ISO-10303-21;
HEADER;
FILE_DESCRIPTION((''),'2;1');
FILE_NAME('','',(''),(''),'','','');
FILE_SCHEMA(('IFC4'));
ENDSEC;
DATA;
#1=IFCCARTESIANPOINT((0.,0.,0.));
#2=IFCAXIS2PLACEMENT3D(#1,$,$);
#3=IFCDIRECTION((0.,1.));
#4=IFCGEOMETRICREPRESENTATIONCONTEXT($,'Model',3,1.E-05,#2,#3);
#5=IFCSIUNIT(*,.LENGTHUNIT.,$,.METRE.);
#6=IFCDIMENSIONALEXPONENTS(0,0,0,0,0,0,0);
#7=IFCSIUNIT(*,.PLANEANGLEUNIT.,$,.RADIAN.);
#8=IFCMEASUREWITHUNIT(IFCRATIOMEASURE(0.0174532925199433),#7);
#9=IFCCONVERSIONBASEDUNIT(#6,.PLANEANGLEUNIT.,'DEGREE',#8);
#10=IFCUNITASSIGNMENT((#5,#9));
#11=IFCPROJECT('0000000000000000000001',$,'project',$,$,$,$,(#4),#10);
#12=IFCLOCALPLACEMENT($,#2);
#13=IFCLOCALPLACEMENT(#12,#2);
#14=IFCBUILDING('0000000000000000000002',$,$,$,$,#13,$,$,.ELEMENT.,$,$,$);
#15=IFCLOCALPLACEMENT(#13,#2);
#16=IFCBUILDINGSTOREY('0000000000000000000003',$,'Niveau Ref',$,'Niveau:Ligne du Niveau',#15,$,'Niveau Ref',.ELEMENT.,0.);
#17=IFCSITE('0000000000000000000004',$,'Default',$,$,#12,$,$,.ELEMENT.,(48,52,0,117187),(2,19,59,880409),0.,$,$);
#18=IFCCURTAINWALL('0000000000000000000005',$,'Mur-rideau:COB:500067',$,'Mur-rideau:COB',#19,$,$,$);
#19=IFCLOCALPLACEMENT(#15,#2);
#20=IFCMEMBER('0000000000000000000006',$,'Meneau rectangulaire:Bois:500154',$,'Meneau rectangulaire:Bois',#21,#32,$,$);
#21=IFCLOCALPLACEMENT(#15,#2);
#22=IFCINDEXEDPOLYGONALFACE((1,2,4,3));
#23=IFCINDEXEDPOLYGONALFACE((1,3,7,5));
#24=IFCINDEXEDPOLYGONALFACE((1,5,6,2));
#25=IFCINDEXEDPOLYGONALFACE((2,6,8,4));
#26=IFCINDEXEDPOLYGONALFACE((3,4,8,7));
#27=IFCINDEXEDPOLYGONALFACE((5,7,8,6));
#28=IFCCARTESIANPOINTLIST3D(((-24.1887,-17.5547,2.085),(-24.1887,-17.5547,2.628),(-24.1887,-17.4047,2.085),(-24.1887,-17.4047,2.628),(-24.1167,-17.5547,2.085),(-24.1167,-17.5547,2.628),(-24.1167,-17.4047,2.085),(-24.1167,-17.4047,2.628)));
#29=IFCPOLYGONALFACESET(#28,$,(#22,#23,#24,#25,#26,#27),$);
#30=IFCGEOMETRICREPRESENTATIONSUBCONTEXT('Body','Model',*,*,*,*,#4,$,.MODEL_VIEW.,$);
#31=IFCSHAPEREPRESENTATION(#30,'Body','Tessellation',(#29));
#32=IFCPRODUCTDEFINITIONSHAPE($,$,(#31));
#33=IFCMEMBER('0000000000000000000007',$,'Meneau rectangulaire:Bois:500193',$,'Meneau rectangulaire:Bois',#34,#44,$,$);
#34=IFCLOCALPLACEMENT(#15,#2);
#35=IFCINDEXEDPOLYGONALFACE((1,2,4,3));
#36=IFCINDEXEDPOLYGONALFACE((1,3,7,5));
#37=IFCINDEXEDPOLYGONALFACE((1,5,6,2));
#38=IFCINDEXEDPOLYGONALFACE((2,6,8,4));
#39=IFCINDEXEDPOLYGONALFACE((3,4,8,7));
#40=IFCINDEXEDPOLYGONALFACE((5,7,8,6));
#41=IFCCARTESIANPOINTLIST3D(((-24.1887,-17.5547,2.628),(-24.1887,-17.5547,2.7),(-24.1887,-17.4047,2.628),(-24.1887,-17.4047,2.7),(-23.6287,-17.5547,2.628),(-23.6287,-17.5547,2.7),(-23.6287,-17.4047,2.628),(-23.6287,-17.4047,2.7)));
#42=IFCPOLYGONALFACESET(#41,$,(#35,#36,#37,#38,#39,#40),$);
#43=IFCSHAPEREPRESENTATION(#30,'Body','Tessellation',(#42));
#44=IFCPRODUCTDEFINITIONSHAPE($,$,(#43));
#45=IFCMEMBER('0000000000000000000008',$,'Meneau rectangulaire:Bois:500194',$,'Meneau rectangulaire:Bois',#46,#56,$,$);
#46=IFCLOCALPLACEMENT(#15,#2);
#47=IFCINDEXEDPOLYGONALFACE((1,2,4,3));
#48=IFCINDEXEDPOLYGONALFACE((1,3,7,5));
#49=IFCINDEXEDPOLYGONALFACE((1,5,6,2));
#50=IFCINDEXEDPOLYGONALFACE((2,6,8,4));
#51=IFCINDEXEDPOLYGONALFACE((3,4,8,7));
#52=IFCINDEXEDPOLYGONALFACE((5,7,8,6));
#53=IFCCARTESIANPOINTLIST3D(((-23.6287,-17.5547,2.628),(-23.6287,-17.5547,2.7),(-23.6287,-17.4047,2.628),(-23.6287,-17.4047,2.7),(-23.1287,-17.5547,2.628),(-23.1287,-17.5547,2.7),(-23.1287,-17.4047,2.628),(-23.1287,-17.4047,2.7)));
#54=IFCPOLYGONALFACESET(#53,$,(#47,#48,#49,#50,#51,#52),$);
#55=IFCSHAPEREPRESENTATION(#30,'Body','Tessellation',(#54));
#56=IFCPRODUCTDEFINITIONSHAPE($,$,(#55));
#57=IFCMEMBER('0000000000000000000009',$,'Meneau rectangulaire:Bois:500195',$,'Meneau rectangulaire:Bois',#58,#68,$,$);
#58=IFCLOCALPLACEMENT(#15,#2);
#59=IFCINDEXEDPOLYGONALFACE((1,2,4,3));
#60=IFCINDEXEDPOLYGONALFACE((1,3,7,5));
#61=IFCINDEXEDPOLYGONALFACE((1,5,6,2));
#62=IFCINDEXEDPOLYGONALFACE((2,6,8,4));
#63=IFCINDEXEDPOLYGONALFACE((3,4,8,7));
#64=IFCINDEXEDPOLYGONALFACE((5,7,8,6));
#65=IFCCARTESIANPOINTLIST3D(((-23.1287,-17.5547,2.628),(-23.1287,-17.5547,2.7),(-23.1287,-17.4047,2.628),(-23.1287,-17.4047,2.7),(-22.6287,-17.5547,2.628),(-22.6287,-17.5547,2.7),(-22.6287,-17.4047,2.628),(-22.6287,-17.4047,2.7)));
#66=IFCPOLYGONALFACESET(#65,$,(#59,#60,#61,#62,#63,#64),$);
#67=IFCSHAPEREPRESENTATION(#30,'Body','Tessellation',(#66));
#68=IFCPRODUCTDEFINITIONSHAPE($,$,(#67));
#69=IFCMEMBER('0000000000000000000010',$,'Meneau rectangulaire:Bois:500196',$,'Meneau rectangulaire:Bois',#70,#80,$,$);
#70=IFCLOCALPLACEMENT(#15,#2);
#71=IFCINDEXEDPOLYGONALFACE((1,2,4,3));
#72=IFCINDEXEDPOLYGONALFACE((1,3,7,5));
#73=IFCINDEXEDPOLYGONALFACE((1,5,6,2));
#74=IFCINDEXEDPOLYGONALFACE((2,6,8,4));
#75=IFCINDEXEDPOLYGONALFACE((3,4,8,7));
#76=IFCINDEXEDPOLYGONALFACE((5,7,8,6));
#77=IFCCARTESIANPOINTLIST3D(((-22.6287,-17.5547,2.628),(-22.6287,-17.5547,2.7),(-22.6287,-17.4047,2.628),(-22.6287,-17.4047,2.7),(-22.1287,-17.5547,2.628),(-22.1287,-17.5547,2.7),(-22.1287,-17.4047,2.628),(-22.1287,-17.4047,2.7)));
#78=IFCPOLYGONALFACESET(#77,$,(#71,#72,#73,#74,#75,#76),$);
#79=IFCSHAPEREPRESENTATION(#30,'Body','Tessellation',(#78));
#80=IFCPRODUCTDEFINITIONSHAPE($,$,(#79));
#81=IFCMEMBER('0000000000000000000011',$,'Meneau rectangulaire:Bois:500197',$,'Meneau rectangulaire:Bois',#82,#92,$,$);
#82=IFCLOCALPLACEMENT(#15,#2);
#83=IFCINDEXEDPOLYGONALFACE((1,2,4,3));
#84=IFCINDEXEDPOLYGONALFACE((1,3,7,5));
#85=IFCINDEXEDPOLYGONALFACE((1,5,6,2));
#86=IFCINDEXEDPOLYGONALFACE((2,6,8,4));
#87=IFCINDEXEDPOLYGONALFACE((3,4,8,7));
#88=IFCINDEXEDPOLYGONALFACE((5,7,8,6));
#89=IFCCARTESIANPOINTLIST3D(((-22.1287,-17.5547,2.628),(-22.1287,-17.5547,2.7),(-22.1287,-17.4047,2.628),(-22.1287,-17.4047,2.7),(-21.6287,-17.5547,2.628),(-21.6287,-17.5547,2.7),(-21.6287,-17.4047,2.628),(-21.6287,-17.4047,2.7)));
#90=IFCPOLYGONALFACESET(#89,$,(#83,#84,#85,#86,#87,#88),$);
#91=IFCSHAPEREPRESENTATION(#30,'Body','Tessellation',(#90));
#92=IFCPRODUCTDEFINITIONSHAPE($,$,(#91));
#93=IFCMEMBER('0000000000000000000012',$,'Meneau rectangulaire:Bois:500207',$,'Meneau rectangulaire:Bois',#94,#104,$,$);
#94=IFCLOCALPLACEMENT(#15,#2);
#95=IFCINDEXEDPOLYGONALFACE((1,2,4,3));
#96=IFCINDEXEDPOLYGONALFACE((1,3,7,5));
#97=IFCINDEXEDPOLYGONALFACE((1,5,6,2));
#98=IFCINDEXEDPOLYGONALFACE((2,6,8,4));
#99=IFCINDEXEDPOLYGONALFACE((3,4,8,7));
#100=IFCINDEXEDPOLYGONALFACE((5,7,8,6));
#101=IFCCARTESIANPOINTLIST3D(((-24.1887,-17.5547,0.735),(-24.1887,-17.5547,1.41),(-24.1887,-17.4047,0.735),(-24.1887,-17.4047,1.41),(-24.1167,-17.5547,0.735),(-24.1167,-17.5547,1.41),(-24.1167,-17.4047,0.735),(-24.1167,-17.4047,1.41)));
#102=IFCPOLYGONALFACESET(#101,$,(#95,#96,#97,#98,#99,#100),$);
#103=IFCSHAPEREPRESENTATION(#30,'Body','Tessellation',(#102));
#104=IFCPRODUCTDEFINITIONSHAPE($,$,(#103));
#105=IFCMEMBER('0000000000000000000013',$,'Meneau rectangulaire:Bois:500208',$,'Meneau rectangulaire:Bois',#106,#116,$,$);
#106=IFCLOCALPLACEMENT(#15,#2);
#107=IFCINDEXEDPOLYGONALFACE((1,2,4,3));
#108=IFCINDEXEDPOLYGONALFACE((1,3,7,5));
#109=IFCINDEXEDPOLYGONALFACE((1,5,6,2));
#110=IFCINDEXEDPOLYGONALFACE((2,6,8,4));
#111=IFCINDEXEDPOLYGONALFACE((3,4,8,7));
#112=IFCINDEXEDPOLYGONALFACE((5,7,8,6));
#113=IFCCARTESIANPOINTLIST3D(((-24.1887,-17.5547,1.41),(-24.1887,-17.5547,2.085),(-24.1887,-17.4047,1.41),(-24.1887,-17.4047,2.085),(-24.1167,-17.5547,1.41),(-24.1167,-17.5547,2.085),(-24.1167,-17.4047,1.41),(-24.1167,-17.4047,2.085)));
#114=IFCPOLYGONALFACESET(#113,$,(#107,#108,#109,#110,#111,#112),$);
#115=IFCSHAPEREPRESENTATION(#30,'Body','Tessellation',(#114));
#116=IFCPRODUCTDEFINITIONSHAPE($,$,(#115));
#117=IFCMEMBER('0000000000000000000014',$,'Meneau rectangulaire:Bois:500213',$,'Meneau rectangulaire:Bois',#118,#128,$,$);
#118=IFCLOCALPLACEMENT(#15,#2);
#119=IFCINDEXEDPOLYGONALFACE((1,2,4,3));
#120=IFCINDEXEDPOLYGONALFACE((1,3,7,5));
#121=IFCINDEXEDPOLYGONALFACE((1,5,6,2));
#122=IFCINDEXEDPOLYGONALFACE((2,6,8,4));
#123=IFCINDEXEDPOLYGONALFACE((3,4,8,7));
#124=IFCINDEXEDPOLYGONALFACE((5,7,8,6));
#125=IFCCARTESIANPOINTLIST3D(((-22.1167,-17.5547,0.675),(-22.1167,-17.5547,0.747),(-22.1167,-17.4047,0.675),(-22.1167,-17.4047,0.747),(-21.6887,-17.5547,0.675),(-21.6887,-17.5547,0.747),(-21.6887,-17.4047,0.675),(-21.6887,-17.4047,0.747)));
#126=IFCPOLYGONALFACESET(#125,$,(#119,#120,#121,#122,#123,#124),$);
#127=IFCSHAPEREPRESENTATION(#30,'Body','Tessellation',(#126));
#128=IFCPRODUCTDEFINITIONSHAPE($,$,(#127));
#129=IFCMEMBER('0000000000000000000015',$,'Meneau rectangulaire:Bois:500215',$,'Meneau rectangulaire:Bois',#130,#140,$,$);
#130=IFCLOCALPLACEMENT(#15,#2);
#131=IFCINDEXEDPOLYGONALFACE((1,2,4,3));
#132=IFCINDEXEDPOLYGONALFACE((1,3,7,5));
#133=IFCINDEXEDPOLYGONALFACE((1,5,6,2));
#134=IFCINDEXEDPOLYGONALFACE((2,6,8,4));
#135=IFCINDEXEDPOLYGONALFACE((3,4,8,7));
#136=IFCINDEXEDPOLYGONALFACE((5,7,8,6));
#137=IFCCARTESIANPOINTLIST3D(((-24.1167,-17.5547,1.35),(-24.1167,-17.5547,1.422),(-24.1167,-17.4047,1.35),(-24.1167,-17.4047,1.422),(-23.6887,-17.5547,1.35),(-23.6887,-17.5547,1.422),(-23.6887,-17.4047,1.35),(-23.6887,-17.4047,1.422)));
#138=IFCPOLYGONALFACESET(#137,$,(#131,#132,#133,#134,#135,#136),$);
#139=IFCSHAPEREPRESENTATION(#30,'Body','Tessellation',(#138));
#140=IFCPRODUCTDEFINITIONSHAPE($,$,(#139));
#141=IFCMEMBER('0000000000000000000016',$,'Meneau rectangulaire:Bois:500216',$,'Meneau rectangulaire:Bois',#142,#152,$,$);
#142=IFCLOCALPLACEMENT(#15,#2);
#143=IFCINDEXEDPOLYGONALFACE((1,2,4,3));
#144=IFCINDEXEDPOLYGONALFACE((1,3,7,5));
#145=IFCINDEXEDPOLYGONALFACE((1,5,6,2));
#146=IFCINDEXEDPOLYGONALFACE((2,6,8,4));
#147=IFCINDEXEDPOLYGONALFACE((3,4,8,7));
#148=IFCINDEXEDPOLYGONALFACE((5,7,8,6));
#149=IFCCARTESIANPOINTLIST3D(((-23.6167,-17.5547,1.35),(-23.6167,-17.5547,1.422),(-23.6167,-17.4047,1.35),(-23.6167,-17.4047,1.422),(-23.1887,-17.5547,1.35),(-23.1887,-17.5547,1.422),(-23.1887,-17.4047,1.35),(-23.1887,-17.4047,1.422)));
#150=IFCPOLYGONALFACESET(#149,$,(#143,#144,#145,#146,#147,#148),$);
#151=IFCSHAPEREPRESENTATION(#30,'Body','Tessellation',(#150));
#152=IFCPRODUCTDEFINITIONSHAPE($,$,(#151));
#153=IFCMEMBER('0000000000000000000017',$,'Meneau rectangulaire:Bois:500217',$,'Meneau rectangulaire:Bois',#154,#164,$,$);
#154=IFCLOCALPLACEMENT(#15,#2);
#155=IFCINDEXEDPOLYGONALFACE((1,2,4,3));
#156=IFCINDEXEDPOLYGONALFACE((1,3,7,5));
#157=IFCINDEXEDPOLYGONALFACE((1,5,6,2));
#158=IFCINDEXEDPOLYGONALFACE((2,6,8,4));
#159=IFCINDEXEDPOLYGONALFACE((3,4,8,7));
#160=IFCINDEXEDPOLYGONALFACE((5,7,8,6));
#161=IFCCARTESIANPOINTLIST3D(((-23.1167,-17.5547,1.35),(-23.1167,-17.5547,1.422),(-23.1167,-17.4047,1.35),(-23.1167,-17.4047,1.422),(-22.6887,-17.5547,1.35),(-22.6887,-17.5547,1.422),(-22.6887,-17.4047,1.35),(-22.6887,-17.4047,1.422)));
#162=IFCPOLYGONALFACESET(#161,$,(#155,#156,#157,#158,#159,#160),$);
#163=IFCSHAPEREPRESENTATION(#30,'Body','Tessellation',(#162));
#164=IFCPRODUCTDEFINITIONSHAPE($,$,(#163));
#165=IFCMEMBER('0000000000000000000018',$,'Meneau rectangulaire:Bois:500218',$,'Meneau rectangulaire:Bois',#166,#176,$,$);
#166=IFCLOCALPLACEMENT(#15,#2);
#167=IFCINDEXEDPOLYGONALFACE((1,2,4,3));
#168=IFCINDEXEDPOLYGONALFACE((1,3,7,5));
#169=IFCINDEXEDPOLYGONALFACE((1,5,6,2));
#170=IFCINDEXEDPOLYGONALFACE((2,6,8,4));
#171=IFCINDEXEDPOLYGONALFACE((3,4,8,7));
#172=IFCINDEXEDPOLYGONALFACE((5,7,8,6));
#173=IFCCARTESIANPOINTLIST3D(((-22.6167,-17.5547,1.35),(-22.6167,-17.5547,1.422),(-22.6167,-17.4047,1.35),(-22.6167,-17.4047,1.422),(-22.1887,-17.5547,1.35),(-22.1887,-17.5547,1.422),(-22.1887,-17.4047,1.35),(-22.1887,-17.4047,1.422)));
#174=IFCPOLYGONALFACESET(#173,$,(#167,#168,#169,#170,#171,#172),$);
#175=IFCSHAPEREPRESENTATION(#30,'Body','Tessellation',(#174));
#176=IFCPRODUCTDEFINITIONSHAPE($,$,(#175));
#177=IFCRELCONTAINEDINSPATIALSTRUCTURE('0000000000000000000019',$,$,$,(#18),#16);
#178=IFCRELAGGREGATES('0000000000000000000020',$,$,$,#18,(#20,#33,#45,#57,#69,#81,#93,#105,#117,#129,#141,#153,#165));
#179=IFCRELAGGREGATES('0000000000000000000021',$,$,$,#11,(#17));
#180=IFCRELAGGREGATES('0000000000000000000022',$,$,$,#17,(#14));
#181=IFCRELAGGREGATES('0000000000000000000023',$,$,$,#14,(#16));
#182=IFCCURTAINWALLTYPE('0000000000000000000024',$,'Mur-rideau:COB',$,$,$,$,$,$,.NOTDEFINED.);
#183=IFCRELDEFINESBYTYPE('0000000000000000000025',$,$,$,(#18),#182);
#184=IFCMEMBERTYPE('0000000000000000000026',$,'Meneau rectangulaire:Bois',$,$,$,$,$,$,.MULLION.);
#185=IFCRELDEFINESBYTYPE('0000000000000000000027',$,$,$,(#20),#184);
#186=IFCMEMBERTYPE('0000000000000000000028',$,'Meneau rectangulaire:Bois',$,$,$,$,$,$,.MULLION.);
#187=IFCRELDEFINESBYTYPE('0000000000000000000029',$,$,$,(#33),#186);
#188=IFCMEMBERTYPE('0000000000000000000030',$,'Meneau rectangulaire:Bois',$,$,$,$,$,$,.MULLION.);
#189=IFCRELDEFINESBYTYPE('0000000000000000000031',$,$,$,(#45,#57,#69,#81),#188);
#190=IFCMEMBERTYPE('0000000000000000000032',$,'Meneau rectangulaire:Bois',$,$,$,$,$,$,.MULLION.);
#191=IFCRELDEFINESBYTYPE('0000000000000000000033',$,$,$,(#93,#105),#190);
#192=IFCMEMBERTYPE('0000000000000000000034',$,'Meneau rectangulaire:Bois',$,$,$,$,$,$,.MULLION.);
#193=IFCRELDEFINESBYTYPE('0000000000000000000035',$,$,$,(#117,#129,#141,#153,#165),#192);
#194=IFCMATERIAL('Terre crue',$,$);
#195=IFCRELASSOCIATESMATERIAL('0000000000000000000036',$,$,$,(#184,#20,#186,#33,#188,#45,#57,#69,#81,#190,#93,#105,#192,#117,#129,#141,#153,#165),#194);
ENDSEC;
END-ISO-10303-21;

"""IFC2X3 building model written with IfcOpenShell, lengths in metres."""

from ifc_helpers import new_model, entity, si_unit, converted_unit, direction, frame, origin, origin_2d_with_axis, place, context, subcontext, project, spatial, rectangle, extrude, source, transform, mapped, material, type_object, type_shapes, element, aggregate, save


model = new_model("IFC2X3")

# Units and contexts
model_context = context("Model", 3, precision=1e-05, world=origin(), true_north=direction((0.0, 1.0)))
body_context = subcontext(model_context, "Body", "Model", "MODEL_VIEW")
ifc_project = project(units=[si_unit("LENGTHUNIT", "METRE"), converted_unit("PLANEANGLEUNIT", "DEGREE", entity("IfcRatioMeasure", 0.0174532925199433), si_unit("PLANEANGLEUNIT", "RADIAN"), dimensions=[0, 0, 0, 0, 0, 0, 0])], contexts=[model_context])

# Site, building, storey
site_placement = place(None, origin())
site = spatial("IfcSite", under=ifc_project, at=site_placement, Name="Default", CompositionType="ELEMENT", RefLatitude=(48, 52, 0, 117187), RefLongitude=(2, 19, 59, 880409), RefElevation=0.0)
building_placement = place(site_placement, origin())
building = spatial("IfcBuilding", under=site, at=building_placement, CompositionType="ELEMENT")
storey_placement = place(building_placement, origin())
storey = spatial("IfcBuildingStorey", under=building, at=storey_placement, Name="Niveau Ref", ObjectType="Niveau:Ligne du Niveau", LongName="Niveau Ref", CompositionType="ELEMENT", Elevation=0.0)

# Curtain wall, members
curtain_wall_type = type_object("IfcCurtainWallType", Name="Mur-rideau:COB", PredefinedType="NOTDEFINED")
curtain_wall_placement = place(storey_placement, origin())
curtain_wall = element("IfcCurtainWall", 1, at=curtain_wall_placement, inside=storey, type_object=curtain_wall_type, Name="Mur-rideau:COB:500067", ObjectType="Mur-rideau:COB")
ifc_material = material(Name="Terre crue")
member_type_1 = type_object("IfcMemberType", Name="Meneau rectangulaire:Bois", PredefinedType="MULLION", material=ifc_material)
shared_shape_1 = source(origin(), body_context, "Body", "SweptSolid", [
    extrude(rectangle(XDim=0.15, YDim=0.072, at=origin_2d_with_axis()), frame((-0.036, 0.0, -0.543), z_axis=(0.0, 0.0, 1.0), x_axis=(0.0, -1.0, 0.0)), (0.0, 0.0, 1.0), 0.543),
])
type_shapes(member_type_1, [shared_shape_1])
member_1_placement = place(storey_placement, frame((-24.1887, -17.4797, 2.628), z_axis=(0.0, 0.0, 1.0), x_axis=(-1.0, 0.0, 0.0)))
member_1 = element("IfcMember", 2, at=member_1_placement, type_object=member_type_1, material=ifc_material, Name="Meneau rectangulaire:Bois:500154", ObjectType="Meneau rectangulaire:Bois", context=body_context, shape_type="MappedRepresentation", body=[
    mapped(shared_shape_1, transform((0.0, 0.0, 0.0), scale=1.0)),
])
member_type_2 = type_object("IfcMemberType", Name="Meneau rectangulaire:Bois", PredefinedType="MULLION", material=ifc_material)
shared_shape_2 = source(origin(), body_context, "Body", "SweptSolid", [
    extrude(rectangle(XDim=0.15, YDim=0.072, at=origin_2d_with_axis()), frame((-0.036, 0.0, -0.56), z_axis=(0.0, 0.0, 1.0), x_axis=(0.0, -1.0, 0.0)), (0.0, 0.0, 1.0), 0.56),
])
type_shapes(member_type_2, [shared_shape_2])
member_2_placement = place(storey_placement, frame((-23.6287, -17.4797, 2.7), z_axis=(1.0, 0.0, 0.0), x_axis=(0.0, 0.0, 1.0)))
member_2 = element("IfcMember", 3, at=member_2_placement, type_object=member_type_2, material=ifc_material, Name="Meneau rectangulaire:Bois:500193", ObjectType="Meneau rectangulaire:Bois", context=body_context, shape_type="MappedRepresentation", body=[
    mapped(shared_shape_2, transform((0.0, 0.0, 0.0), scale=1.0)),
])
member_type_3 = type_object("IfcMemberType", Name="Meneau rectangulaire:Bois", PredefinedType="MULLION", material=ifc_material)
shared_shape_3 = source(origin(), body_context, "Body", "SweptSolid", [
    extrude(rectangle(XDim=0.15, YDim=0.072, at=origin_2d_with_axis()), frame((-0.036, 0.0, -0.5), z_axis=(0.0, 0.0, 1.0), x_axis=(0.0, -1.0, 0.0)), (0.0, 0.0, 1.0), 0.5),
])
type_shapes(member_type_3, [shared_shape_3])
member_3_placement = place(storey_placement, frame((-23.1287, -17.4797, 2.7), z_axis=(1.0, 0.0, 0.0), x_axis=(0.0, 0.0, 1.0)))
member_3 = element("IfcMember", 4, at=member_3_placement, type_object=member_type_3, material=ifc_material, Name="Meneau rectangulaire:Bois:500194", ObjectType="Meneau rectangulaire:Bois", context=body_context, shape_type="MappedRepresentation", body=[
    mapped(shared_shape_3, transform((0.0, 0.0, 0.0), scale=1.0)),
])
member_4_placement = place(storey_placement, frame((-22.6287, -17.4797, 2.7), z_axis=(1.0, 0.0, 0.0), x_axis=(0.0, 0.0, 1.0)))
member_4 = element("IfcMember", 5, at=member_4_placement, type_object=member_type_3, material=ifc_material, Name="Meneau rectangulaire:Bois:500195", ObjectType="Meneau rectangulaire:Bois", context=body_context, shape_type="MappedRepresentation", body=[
    mapped(shared_shape_3, transform((0.0, 0.0, 0.0), scale=1.0)),
])
member_5_placement = place(storey_placement, frame((-22.1287, -17.4797, 2.7), z_axis=(1.0, 0.0, 0.0), x_axis=(0.0, 0.0, 1.0)))
member_5 = element("IfcMember", 6, at=member_5_placement, type_object=member_type_3, material=ifc_material, Name="Meneau rectangulaire:Bois:500196", ObjectType="Meneau rectangulaire:Bois", context=body_context, shape_type="MappedRepresentation", body=[
    mapped(shared_shape_3, transform((0.0, 0.0, 0.0), scale=1.0)),
])
member_6_placement = place(storey_placement, frame((-21.6287, -17.4797, 2.7), z_axis=(1.0, 0.0, 0.0), x_axis=(0.0, 0.0, 1.0)))
member_6 = element("IfcMember", 7, at=member_6_placement, type_object=member_type_3, material=ifc_material, Name="Meneau rectangulaire:Bois:500197", ObjectType="Meneau rectangulaire:Bois", context=body_context, shape_type="MappedRepresentation", body=[
    mapped(shared_shape_3, transform((0.0, 0.0, 0.0), scale=1.0)),
])
member_type_4 = type_object("IfcMemberType", Name="Meneau rectangulaire:Bois", PredefinedType="MULLION", material=ifc_material)
shared_shape_4 = source(origin(), body_context, "Body", "SweptSolid", [
    extrude(rectangle(XDim=0.15, YDim=0.072, at=origin_2d_with_axis()), frame((-0.036, 0.0, -0.675), z_axis=(0.0, 0.0, 1.0), x_axis=(0.0, -1.0, 0.0)), (0.0, 0.0, 1.0), 0.675),
])
type_shapes(member_type_4, [shared_shape_4])
member_7_placement = place(storey_placement, frame((-24.1887, -17.4797, 1.41), z_axis=(0.0, 0.0, 1.0), x_axis=(-1.0, 0.0, 0.0)))
member_7 = element("IfcMember", 8, at=member_7_placement, type_object=member_type_4, material=ifc_material, Name="Meneau rectangulaire:Bois:500207", ObjectType="Meneau rectangulaire:Bois", context=body_context, shape_type="MappedRepresentation", body=[
    mapped(shared_shape_4, transform((0.0, 0.0, 0.0), scale=1.0)),
])
member_8_placement = place(storey_placement, frame((-24.1887, -17.4797, 2.085), z_axis=(0.0, 0.0, 1.0), x_axis=(-1.0, 0.0, 0.0)))
member_8 = element("IfcMember", 9, at=member_8_placement, type_object=member_type_4, material=ifc_material, Name="Meneau rectangulaire:Bois:500208", ObjectType="Meneau rectangulaire:Bois", context=body_context, shape_type="MappedRepresentation", body=[
    mapped(shared_shape_4, transform((0.0, 0.0, 0.0), scale=1.0)),
])
member_type_5 = type_object("IfcMemberType", Name="Meneau rectangulaire:Bois", PredefinedType="MULLION", material=ifc_material)
shared_shape_5 = source(origin(), body_context, "Body", "SweptSolid", [
    extrude(rectangle(XDim=0.15, YDim=0.072, at=origin_2d_with_axis()), frame((-0.024, 0.0, -0.428), z_axis=(0.0, 0.0, 1.0), x_axis=(0.0, -1.0, 0.0)), (0.0, 0.0, 1.0), 0.428),
])
type_shapes(member_type_5, [shared_shape_5])
member_9_placement = place(storey_placement, frame((-21.6887, -17.4797, 0.735), z_axis=(1.0, 0.0, 0.0), x_axis=(0.0, 0.0, 1.0)))
member_9 = element("IfcMember", 10, at=member_9_placement, type_object=member_type_5, material=ifc_material, Name="Meneau rectangulaire:Bois:500213", ObjectType="Meneau rectangulaire:Bois", context=body_context, shape_type="MappedRepresentation", body=[
    mapped(shared_shape_5, transform((0.0, 0.0, 0.0), scale=1.0)),
])
member_10_placement = place(storey_placement, frame((-23.6887, -17.4797, 1.41), z_axis=(1.0, 0.0, 0.0), x_axis=(0.0, 0.0, 1.0)))
member_10 = element("IfcMember", 11, at=member_10_placement, type_object=member_type_5, material=ifc_material, Name="Meneau rectangulaire:Bois:500215", ObjectType="Meneau rectangulaire:Bois", context=body_context, shape_type="MappedRepresentation", body=[
    mapped(shared_shape_5, transform((0.0, 0.0, 0.0), scale=1.0)),
])
member_11_placement = place(storey_placement, frame((-23.1887, -17.4797, 1.41), z_axis=(1.0, 0.0, 0.0), x_axis=(0.0, 0.0, 1.0)))
member_11 = element("IfcMember", 12, at=member_11_placement, type_object=member_type_5, material=ifc_material, Name="Meneau rectangulaire:Bois:500216", ObjectType="Meneau rectangulaire:Bois", context=body_context, shape_type="MappedRepresentation", body=[
    mapped(shared_shape_5, transform((0.0, 0.0, 0.0), scale=1.0)),
])
member_12_placement = place(storey_placement, frame((-22.6887, -17.4797, 1.41), z_axis=(1.0, 0.0, 0.0), x_axis=(0.0, 0.0, 1.0)))
member_12 = element("IfcMember", 13, at=member_12_placement, type_object=member_type_5, material=ifc_material, Name="Meneau rectangulaire:Bois:500217", ObjectType="Meneau rectangulaire:Bois", context=body_context, shape_type="MappedRepresentation", body=[
    mapped(shared_shape_5, transform((0.0, 0.0, 0.0), scale=1.0)),
])
member_13_placement = place(storey_placement, frame((-22.1887, -17.4797, 1.41), z_axis=(1.0, 0.0, 0.0), x_axis=(0.0, 0.0, 1.0)))
member_13 = element("IfcMember", 14, at=member_13_placement, type_object=member_type_5, material=ifc_material, Name="Meneau rectangulaire:Bois:500218", ObjectType="Meneau rectangulaire:Bois", context=body_context, shape_type="MappedRepresentation", body=[
    mapped(shared_shape_5, transform((0.0, 0.0, 0.0), scale=1.0)),
])
aggregate(curtain_wall, [member_1, member_2, member_3, member_4, member_5, member_6, member_7, member_8, member_9, member_10, member_11, member_12, member_13])

save(model, "model.ifc")
